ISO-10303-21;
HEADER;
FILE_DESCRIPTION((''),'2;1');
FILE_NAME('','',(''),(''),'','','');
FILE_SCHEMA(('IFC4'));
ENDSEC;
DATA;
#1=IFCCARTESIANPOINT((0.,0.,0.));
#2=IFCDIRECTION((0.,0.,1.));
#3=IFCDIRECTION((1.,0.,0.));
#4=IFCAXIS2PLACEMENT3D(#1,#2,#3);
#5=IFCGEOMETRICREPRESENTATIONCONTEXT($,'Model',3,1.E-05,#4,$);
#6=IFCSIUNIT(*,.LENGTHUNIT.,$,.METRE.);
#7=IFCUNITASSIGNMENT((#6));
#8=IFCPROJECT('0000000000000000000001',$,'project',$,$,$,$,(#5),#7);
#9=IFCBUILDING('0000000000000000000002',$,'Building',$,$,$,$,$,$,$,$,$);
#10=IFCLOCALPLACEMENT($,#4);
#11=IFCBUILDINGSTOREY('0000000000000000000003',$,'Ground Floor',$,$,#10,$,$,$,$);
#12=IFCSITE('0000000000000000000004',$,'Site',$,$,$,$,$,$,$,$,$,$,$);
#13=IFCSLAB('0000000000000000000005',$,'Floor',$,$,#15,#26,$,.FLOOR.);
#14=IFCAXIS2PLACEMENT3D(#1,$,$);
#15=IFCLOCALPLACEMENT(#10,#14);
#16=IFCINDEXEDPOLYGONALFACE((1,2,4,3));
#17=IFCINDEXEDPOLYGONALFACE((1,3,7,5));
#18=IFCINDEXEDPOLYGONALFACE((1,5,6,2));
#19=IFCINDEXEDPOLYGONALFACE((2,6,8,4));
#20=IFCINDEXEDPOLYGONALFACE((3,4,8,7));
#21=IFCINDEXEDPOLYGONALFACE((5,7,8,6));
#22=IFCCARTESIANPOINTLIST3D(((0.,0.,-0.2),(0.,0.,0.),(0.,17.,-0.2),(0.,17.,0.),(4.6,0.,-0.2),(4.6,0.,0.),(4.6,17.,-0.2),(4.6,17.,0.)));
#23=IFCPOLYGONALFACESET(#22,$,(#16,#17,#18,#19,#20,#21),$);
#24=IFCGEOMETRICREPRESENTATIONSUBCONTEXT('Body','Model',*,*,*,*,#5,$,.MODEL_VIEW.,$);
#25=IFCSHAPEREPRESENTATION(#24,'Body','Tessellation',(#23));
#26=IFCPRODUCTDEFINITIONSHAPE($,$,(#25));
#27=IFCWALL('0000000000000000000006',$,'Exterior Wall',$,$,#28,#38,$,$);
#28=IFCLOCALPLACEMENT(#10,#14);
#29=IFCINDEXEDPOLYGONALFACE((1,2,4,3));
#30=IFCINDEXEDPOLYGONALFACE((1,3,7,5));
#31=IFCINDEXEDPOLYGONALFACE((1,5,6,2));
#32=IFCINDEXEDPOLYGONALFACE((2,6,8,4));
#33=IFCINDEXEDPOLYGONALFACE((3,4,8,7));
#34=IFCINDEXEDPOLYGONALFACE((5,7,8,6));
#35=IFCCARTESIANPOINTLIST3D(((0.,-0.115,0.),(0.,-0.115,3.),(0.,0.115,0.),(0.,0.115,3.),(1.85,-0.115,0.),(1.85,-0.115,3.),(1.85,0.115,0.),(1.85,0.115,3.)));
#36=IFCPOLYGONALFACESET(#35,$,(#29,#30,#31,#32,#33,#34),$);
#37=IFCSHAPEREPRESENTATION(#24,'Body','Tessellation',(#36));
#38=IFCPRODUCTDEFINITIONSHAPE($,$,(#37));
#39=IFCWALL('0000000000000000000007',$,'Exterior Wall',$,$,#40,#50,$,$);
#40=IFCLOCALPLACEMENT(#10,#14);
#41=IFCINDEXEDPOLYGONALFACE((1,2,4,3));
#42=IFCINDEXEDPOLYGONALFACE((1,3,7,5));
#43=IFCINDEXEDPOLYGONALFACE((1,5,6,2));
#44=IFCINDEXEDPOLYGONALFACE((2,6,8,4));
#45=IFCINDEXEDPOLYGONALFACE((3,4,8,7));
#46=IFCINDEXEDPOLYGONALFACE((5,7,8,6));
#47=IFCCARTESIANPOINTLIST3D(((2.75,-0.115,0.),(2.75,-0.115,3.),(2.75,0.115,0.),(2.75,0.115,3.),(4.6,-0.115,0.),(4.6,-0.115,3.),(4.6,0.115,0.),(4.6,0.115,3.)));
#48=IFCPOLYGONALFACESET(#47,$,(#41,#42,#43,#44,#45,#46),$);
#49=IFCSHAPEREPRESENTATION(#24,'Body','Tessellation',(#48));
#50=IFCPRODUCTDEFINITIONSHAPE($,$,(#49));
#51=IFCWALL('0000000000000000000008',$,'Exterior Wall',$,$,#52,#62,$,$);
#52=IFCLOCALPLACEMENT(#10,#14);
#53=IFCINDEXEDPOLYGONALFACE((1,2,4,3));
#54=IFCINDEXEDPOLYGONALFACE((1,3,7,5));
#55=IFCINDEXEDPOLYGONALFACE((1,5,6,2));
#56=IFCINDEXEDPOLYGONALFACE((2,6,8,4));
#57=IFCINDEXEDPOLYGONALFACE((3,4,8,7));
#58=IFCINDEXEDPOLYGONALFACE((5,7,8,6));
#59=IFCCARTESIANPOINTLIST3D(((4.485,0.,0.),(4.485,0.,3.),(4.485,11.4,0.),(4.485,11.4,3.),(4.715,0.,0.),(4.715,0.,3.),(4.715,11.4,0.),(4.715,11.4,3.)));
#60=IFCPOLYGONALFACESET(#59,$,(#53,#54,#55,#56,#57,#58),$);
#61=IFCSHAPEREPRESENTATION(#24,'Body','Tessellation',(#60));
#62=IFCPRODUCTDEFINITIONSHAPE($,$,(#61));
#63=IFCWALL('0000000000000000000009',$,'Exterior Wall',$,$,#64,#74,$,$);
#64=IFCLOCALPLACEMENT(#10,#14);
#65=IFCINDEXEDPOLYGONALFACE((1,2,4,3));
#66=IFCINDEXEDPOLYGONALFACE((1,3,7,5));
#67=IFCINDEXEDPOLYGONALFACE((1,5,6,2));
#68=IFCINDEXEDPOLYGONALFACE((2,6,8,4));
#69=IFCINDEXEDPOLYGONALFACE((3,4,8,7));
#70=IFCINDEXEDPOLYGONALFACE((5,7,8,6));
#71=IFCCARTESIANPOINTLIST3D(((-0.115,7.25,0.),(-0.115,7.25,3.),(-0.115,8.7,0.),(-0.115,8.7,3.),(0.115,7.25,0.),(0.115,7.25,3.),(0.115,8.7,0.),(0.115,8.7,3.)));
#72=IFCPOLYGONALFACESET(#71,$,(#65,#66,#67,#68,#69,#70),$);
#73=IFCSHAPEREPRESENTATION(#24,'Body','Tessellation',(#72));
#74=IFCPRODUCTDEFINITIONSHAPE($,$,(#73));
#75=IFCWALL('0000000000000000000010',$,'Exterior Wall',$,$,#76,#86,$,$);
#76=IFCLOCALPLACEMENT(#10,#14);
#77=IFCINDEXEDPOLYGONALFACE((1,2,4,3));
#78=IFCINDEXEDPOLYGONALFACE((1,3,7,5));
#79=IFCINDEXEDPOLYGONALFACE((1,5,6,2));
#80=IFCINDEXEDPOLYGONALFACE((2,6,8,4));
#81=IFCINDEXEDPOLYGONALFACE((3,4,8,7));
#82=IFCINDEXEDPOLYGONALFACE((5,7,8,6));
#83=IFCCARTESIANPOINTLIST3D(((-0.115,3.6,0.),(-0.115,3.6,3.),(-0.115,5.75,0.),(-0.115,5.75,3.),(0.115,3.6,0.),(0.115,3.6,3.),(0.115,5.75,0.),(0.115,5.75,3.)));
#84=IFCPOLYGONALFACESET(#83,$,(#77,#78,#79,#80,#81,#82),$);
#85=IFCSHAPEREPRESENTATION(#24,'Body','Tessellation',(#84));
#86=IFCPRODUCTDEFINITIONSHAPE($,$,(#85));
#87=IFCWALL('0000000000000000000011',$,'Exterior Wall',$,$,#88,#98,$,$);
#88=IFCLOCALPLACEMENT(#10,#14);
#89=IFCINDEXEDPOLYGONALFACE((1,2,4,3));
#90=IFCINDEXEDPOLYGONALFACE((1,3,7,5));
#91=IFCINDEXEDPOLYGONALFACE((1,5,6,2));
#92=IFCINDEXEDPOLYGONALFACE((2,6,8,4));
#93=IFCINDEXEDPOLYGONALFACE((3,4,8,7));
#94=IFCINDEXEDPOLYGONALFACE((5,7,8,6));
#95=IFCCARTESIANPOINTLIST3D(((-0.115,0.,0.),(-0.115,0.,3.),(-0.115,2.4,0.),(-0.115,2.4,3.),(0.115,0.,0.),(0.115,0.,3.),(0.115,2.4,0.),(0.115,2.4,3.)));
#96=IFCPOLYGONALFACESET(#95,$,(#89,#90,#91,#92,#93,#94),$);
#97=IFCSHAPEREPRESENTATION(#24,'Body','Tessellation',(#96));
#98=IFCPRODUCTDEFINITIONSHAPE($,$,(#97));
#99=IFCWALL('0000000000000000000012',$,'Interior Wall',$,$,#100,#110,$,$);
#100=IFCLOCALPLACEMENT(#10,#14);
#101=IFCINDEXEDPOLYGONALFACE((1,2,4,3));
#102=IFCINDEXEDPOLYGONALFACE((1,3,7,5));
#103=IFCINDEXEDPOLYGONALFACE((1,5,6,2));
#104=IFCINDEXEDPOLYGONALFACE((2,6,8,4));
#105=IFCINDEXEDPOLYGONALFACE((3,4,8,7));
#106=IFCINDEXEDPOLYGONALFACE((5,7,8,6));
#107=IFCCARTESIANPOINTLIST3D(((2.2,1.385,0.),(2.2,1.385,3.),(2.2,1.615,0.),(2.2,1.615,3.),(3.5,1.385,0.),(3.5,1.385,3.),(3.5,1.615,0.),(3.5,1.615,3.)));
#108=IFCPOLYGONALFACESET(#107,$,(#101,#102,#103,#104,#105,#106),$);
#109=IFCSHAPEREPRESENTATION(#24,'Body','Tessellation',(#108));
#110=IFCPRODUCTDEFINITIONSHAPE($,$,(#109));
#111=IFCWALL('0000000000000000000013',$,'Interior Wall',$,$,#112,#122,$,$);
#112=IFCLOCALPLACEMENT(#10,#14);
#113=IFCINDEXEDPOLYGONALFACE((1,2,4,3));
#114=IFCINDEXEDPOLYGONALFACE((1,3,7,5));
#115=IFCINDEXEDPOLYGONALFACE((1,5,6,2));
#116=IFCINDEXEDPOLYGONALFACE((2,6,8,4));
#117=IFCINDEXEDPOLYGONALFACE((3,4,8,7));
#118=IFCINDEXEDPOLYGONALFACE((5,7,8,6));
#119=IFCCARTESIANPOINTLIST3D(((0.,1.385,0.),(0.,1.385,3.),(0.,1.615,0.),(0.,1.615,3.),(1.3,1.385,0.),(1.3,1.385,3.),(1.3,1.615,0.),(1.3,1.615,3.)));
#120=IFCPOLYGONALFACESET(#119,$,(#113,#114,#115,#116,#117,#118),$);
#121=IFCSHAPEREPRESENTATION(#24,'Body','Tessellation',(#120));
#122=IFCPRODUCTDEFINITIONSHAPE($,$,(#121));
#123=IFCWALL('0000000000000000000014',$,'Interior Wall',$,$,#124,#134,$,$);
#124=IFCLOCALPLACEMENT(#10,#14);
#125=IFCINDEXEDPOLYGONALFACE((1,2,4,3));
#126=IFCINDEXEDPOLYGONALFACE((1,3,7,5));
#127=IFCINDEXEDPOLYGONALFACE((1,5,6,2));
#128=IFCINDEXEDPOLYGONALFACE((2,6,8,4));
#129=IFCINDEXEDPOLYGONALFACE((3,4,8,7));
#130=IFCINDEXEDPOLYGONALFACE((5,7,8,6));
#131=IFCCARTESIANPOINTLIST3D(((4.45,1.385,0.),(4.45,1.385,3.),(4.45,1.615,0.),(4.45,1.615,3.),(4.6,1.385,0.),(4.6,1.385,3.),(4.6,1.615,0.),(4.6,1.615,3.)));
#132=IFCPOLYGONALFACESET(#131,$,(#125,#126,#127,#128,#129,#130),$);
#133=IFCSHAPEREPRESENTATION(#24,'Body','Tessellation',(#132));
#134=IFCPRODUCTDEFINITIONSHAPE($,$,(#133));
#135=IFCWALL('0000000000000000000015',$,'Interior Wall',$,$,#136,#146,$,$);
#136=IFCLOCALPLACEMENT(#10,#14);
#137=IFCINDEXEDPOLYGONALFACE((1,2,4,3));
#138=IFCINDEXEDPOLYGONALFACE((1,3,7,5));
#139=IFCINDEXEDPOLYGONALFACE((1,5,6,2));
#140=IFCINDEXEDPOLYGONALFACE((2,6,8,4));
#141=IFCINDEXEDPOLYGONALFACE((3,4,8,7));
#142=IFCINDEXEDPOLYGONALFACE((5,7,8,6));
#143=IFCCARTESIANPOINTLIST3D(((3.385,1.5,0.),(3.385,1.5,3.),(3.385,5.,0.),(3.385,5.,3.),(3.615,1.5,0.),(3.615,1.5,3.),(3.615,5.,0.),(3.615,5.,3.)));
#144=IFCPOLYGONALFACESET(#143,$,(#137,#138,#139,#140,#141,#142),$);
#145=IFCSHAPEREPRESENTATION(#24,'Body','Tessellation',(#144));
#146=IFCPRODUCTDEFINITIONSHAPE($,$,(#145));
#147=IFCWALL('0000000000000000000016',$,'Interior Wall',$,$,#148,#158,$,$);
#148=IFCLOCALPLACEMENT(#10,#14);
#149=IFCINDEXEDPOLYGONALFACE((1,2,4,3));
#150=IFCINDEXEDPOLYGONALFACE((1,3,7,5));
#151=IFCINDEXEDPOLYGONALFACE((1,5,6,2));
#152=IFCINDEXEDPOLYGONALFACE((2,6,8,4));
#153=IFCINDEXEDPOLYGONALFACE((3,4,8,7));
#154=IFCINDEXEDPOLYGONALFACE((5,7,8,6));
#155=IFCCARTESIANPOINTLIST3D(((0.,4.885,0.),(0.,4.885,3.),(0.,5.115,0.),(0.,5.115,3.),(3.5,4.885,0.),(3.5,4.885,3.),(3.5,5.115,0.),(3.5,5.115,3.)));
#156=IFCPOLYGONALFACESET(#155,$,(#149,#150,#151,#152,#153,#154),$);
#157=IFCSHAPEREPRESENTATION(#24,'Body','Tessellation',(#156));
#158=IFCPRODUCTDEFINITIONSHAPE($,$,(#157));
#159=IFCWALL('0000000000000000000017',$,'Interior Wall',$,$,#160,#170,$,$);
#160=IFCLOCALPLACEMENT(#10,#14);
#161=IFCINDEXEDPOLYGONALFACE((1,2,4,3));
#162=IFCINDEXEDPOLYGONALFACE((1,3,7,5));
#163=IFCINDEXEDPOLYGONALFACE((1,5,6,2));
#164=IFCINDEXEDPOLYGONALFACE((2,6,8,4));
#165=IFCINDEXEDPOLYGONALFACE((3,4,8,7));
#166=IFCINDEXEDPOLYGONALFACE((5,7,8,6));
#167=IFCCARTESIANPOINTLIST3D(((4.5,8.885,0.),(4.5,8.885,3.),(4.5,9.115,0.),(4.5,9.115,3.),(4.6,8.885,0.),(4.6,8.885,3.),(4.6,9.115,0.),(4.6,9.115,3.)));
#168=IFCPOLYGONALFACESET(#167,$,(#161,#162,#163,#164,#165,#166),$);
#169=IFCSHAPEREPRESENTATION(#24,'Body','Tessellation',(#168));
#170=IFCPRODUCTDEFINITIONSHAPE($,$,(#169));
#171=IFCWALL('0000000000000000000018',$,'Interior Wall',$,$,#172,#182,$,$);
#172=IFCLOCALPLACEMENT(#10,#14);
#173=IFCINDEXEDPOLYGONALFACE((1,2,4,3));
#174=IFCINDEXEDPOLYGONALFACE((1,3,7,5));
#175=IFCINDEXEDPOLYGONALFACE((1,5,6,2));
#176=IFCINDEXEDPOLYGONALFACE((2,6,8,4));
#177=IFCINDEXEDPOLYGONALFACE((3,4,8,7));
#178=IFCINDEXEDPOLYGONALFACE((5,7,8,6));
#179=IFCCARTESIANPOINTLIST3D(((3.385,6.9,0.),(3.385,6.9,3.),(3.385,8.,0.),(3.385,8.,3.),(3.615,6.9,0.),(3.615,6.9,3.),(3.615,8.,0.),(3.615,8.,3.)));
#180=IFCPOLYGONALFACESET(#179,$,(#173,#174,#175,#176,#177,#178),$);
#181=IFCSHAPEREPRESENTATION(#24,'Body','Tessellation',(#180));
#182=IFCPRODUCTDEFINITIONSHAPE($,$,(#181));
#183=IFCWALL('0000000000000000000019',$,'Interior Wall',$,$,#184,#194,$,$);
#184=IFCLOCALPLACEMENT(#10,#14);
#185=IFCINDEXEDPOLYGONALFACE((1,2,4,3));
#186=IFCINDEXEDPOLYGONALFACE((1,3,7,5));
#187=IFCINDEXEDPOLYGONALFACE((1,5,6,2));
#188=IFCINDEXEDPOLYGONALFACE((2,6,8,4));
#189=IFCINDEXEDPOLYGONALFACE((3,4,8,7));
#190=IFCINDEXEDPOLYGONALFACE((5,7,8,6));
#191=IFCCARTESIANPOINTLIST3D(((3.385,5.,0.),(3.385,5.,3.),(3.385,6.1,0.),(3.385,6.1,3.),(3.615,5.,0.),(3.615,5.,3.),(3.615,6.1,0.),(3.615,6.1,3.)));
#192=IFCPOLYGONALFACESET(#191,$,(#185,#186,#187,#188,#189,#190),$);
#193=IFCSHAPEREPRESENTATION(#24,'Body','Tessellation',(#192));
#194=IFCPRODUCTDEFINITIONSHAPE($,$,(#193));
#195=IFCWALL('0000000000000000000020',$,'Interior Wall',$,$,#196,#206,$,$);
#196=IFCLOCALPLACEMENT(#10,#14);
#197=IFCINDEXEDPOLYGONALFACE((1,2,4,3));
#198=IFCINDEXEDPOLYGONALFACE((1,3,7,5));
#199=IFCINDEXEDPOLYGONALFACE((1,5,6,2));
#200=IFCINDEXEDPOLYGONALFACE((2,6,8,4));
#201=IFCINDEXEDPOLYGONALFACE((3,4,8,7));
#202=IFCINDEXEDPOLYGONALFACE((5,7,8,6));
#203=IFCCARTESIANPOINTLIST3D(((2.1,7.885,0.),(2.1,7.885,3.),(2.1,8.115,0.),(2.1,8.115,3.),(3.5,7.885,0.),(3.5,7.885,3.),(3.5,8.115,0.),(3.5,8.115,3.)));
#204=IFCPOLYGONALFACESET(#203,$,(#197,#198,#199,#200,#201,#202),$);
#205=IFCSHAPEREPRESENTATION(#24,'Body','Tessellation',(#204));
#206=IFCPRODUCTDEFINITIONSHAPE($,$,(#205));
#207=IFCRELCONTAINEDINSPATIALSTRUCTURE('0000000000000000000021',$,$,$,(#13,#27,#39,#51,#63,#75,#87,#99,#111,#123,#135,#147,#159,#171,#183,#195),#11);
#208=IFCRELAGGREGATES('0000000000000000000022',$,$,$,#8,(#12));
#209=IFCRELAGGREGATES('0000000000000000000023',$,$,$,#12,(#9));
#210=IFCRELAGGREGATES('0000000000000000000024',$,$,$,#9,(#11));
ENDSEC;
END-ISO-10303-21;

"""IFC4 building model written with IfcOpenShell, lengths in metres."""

from ifc_helpers import new_model, si_unit, frame, origin_with_axes, place, context, subcontext, project, spatial, indexed_curve, outline, extrude, element, save


model = new_model("IFC4")

# Units and contexts
model_context = context("Model", 3, precision=1e-05, world=origin_with_axes())
body_context = subcontext(model_context, "Body", "Model", "MODEL_VIEW")
ifc_project = project(units=[si_unit("LENGTHUNIT", "METRE")], contexts=[model_context])

# Site, building, storey
site = spatial("IfcSite", under=ifc_project, Name="Site")
building = spatial("IfcBuilding", under=site, Name="Building")
storey_placement = place(None, origin_with_axes())
storey = spatial("IfcBuildingStorey", under=building, at=storey_placement, Name="Ground Floor")

# Slab
slab_placement = place(storey_placement, frame((0.0, 0.0, -0.2), z_axis=(0.0, 0.0, 1.0), x_axis=(1.0, 0.0, 0.0)))
element("IfcSlab", 1, at=slab_placement, inside=storey, Name="Floor", PredefinedType="FLOOR", context=body_context, shape_type="SweptSolid", body=[
    extrude(outline(indexed_curve([(0.0, 0.0), (4.6, 0.0), (4.6, 17.0), (0.0, 17.0)])), None, (0.0, 0.0, 1.0), 0.2),
])

# Walls
wall_1_placement = place(storey_placement, origin_with_axes())
element("IfcWall", 2, at=wall_1_placement, inside=storey, Name="Exterior Wall", context=body_context, shape_type="SweptSolid", body=[
    extrude(outline(indexed_curve([(0.0, 0.0), (0.0, 0.23), (1.85, 0.23), (1.85, 0.0), (0.0, 0.0)], self_intersect=False)), frame((0.0, -0.115, 0.0), z_axis=(0.0, 0.0, 1.0), x_axis=(1.0, 0.0, 0.0)), (0.0, 0.0, 1.0), 3.0),
])
wall_2_placement = place(storey_placement, frame((2.75, 0.0, 0.0), z_axis=(0.0, 0.0, 1.0), x_axis=(1.0, 0.0, 0.0)))
element("IfcWall", 3, at=wall_2_placement, inside=storey, Name="Exterior Wall", context=body_context, shape_type="SweptSolid", body=[
    extrude(outline(indexed_curve([(0.0, 0.0), (0.0, 0.23), (1.85, 0.23), (1.85, 0.0), (0.0, 0.0)], self_intersect=False)), frame((0.0, -0.115, 0.0), z_axis=(0.0, 0.0, 1.0), x_axis=(1.0, 0.0, 0.0)), (0.0, 0.0, 1.0), 3.0),
])
wall_3_placement = place(storey_placement, frame((4.6, 0.0, 0.0), z_axis=(0.0, 0.0, 1.0), x_axis=(0.0, 1.0, 0.0)))
element("IfcWall", 4, at=wall_3_placement, inside=storey, Name="Exterior Wall", context=body_context, shape_type="SweptSolid", body=[
    extrude(outline(indexed_curve([(0.0, 0.0), (0.0, 0.23), (11.4, 0.23), (11.4, 0.0), (0.0, 0.0)], self_intersect=False)), frame((0.0, -0.115, 0.0), z_axis=(0.0, 0.0, 1.0), x_axis=(1.0, 0.0, 0.0)), (0.0, 0.0, 1.0), 3.0),
])
wall_4_placement = place(storey_placement, frame((0.0, 8.7, 0.0), z_axis=(0.0, 0.0, 1.0), x_axis=(0.0, -1.0, 0.0)))
element("IfcWall", 5, at=wall_4_placement, inside=storey, Name="Exterior Wall", context=body_context, shape_type="SweptSolid", body=[
    extrude(outline(indexed_curve([(0.0, 0.0), (0.0, 0.23), (1.45, 0.23), (1.45, 0.0), (0.0, 0.0)], self_intersect=False)), frame((0.0, -0.115, 0.0), z_axis=(0.0, 0.0, 1.0), x_axis=(1.0, 0.0, 0.0)), (0.0, 0.0, 1.0), 3.0),
])
wall_5_placement = place(storey_placement, frame((0.0, 5.75, 0.0), z_axis=(0.0, 0.0, 1.0), x_axis=(0.0, -1.0, 0.0)))
element("IfcWall", 6, at=wall_5_placement, inside=storey, Name="Exterior Wall", context=body_context, shape_type="SweptSolid", body=[
    extrude(outline(indexed_curve([(0.0, 0.0), (0.0, 0.23), (2.15, 0.23), (2.15, 0.0), (0.0, 0.0)], self_intersect=False)), frame((0.0, -0.115, 0.0), z_axis=(0.0, 0.0, 1.0), x_axis=(1.0, 0.0, 0.0)), (0.0, 0.0, 1.0), 3.0),
])
wall_6_placement = place(storey_placement, frame((0.0, 2.4, 0.0), z_axis=(0.0, 0.0, 1.0), x_axis=(0.0, -1.0, 0.0)))
element("IfcWall", 7, at=wall_6_placement, inside=storey, Name="Exterior Wall", context=body_context, shape_type="SweptSolid", body=[
    extrude(outline(indexed_curve([(0.0, 0.0), (0.0, 0.23), (2.4, 0.23), (2.4, 0.0), (0.0, 0.0)], self_intersect=False)), frame((0.0, -0.115, 0.0), z_axis=(0.0, 0.0, 1.0), x_axis=(1.0, 0.0, 0.0)), (0.0, 0.0, 1.0), 3.0),
])
for number, where, z_axis, x_axis, name in (
    (8, (3.5, 1.5, 0.0), (0.0, 0.0, 1.0), (-1.0, 0.0, 0.0), "Interior Wall"),
    (9, (1.3, 1.5, 0.0), (0.0, 0.0, 1.0), (-1.0, 0.0, 0.0), "Interior Wall"),
):
    element("IfcWall", number, at=place(storey_placement, frame(where, z_axis=z_axis, x_axis=x_axis)), inside=storey, Name=name, context=body_context, shape_type="SweptSolid", body=[
        extrude(outline(indexed_curve([(0.0, 0.0), (0.0, 0.23), (1.3, 0.23), (1.3, 0.0), (0.0, 0.0)], self_intersect=False)), frame((0.0, -0.115, 0.0), z_axis=(0.0, 0.0, 1.0), x_axis=(1.0, 0.0, 0.0)), (0.0, 0.0, 1.0), 3.0),
    ])
wall_7_placement = place(storey_placement, frame((4.6, 1.5, 0.0), z_axis=(0.0, 0.0, 1.0), x_axis=(-1.0, 0.0, 0.0)))
element("IfcWall", 10, at=wall_7_placement, inside=storey, Name="Interior Wall", context=body_context, shape_type="SweptSolid", body=[
    extrude(outline(indexed_curve([(0.0, 0.0), (0.0, 0.23), (0.15, 0.23), (0.15, 0.0), (0.0, 0.0)], self_intersect=False)), frame((0.0, -0.115, 0.0), z_axis=(0.0, 0.0, 1.0), x_axis=(1.0, 0.0, 0.0)), (0.0, 0.0, 1.0), 3.0),
])
for number, where, z_axis, x_axis, name in (
    (11, (3.5, 1.5, 0.0), (0.0, 0.0, 1.0), (0.0, 1.0, 0.0), "Interior Wall"),
    (12, (3.5, 5.0, 0.0), (0.0, 0.0, 1.0), (-1.0, 0.0, 0.0), "Interior Wall"),
):
    element("IfcWall", number, at=place(storey_placement, frame(where, z_axis=z_axis, x_axis=x_axis)), inside=storey, Name=name, context=body_context, shape_type="SweptSolid", body=[
        extrude(outline(indexed_curve([(0.0, 0.0), (0.0, 0.23), (3.5, 0.23), (3.5, 0.0), (0.0, 0.0)], self_intersect=False)), frame((0.0, -0.115, 0.0), z_axis=(0.0, 0.0, 1.0), x_axis=(1.0, 0.0, 0.0)), (0.0, 0.0, 1.0), 3.0),
    ])
wall_8_placement = place(storey_placement, frame((4.6, 9.0, 0.0), z_axis=(0.0, 0.0, 1.0), x_axis=(-1.0, 0.0, 0.0)))
element("IfcWall", 13, at=wall_8_placement, inside=storey, Name="Interior Wall", context=body_context, shape_type="SweptSolid", body=[
    extrude(outline(indexed_curve([(0.0, 0.0), (0.0, 0.23), (0.1, 0.23), (0.1, 0.0), (0.0, 0.0)], self_intersect=False)), frame((0.0, -0.115, 0.0), z_axis=(0.0, 0.0, 1.0), x_axis=(1.0, 0.0, 0.0)), (0.0, 0.0, 1.0), 3.0),
])
for number, where, z_axis, x_axis, name in (
    (14, (3.5, 8.0, 0.0), (0.0, 0.0, 1.0), (0.0, -1.0, 0.0), "Interior Wall"),
    (15, (3.5, 6.1, 0.0), (0.0, 0.0, 1.0), (0.0, -1.0, 0.0), "Interior Wall"),
):
    element("IfcWall", number, at=place(storey_placement, frame(where, z_axis=z_axis, x_axis=x_axis)), inside=storey, Name=name, context=body_context, shape_type="SweptSolid", body=[
        extrude(outline(indexed_curve([(0.0, 0.0), (0.0, 0.23), (1.1, 0.23), (1.1, 0.0), (0.0, 0.0)], self_intersect=False)), frame((0.0, -0.115, 0.0), z_axis=(0.0, 0.0, 1.0), x_axis=(1.0, 0.0, 0.0)), (0.0, 0.0, 1.0), 3.0),
    ])
for number, where, z_axis, x_axis, name in (
    (16, (3.5, 8.0, 0.0), (0.0, 0.0, 1.0), (-1.0, 0.0, 0.0), "Interior Wall"),
):
    element("IfcWall", number, at=place(storey_placement, frame(where, z_axis=z_axis, x_axis=x_axis)), inside=storey, Name=name, context=body_context, shape_type="SweptSolid", body=[
        extrude(outline(indexed_curve([(0.0, 0.0), (0.0, 0.23), (1.4, 0.23), (1.4, 0.0), (0.0, 0.0)], self_intersect=False)), frame((0.0, -0.115, 0.0), z_axis=(0.0, 0.0, 1.0), x_axis=(1.0, 0.0, 0.0)), (0.0, 0.0, 1.0), 3.0),
    ])

save(model, "model.ifc")
